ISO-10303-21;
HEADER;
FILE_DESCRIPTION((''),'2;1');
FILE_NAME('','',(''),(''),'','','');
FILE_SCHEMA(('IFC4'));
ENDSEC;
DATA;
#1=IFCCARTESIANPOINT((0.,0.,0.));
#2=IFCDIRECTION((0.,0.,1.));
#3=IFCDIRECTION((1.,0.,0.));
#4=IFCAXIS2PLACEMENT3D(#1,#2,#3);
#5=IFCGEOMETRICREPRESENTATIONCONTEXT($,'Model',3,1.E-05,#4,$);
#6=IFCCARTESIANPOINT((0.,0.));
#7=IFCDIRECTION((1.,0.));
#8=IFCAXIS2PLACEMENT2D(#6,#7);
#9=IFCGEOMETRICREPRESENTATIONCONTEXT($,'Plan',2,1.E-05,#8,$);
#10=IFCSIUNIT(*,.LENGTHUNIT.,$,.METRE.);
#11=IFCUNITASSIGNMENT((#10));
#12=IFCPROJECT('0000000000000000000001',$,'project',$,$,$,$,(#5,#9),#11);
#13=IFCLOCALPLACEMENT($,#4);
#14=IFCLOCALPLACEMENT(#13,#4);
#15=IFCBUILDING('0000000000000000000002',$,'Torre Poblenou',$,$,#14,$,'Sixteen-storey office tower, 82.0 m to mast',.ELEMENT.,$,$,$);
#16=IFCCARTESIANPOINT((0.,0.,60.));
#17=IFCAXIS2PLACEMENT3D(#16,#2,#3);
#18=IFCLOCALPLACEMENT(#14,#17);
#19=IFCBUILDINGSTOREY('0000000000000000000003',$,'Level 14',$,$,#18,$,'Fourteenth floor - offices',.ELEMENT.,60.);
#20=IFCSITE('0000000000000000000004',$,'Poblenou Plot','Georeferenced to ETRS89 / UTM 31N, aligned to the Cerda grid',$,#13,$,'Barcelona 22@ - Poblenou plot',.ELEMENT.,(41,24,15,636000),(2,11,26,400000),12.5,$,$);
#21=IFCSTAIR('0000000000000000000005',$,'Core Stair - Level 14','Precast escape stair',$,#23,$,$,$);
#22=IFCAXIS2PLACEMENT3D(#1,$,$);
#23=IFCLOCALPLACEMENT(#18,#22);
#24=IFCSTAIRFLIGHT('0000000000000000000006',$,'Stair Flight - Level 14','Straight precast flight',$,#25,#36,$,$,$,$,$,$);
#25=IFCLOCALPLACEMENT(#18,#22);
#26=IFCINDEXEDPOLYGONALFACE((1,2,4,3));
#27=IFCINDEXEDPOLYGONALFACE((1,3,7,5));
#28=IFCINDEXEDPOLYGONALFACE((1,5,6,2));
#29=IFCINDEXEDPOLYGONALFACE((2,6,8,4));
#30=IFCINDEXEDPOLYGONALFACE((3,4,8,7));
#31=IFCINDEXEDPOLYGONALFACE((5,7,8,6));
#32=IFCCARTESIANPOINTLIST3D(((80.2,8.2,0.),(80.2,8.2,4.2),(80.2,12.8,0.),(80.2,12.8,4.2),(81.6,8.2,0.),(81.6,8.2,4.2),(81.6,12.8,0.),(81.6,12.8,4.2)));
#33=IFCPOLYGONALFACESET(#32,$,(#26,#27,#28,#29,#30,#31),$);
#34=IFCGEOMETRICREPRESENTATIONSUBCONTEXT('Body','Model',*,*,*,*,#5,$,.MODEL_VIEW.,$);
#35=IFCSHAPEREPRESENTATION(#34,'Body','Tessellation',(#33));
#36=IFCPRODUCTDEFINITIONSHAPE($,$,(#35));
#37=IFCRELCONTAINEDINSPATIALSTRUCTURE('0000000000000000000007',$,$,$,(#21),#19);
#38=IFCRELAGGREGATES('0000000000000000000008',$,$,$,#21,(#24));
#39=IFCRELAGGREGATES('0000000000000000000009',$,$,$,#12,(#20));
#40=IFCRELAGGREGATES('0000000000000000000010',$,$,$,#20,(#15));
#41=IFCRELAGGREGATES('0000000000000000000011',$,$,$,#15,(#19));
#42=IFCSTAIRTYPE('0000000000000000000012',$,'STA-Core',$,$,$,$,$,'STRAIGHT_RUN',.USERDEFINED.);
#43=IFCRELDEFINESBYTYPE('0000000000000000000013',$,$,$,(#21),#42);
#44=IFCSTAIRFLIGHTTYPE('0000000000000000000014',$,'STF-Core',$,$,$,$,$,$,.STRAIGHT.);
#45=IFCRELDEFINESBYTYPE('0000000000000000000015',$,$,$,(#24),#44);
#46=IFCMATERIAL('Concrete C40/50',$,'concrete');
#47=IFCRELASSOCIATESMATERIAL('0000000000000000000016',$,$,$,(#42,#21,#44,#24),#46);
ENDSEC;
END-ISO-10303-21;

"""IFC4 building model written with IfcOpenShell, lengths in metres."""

from ifc_helpers import new_model, si_unit, frame, origin_with_axes, origin_2d_with_axis, place, context, subcontext, project, spatial, line, indexed_curve, outline, extrude, material, type_object, element, aggregate, save


model = new_model("IFC4")

# Units and contexts
model_context = context("Model", 3, precision=1e-05, world=origin_with_axes())
plan_context = context("Plan", 2, precision=1e-05, world=origin_2d_with_axis())
body_context = subcontext(model_context, "Body", "Model", "MODEL_VIEW")
ifc_project = project(units=[si_unit("LENGTHUNIT", "METRE")], contexts=[model_context, plan_context])

# Site, building, storey
site_placement = place(None, origin_with_axes())
site = spatial("IfcSite", under=ifc_project, at=site_placement, Name="Poblenou Plot", Description="Georeferenced to ETRS89 / UTM 31N, aligned to the Cerda grid", LongName="Barcelona 22@ - Poblenou plot", CompositionType="ELEMENT", RefLatitude=(41, 24, 15, 636000), RefLongitude=(2, 11, 26, 400000), RefElevation=12.5)
building_placement = place(site_placement, origin_with_axes())
building = spatial("IfcBuilding", under=site, at=building_placement, Name="Torre Poblenou", LongName="Sixteen-storey office tower, 82.0 m to mast", CompositionType="ELEMENT")
storey_placement = place(building_placement, frame((0.0, 0.0, 60.0), z_axis=(0.0, 0.0, 1.0), x_axis=(1.0, 0.0, 0.0)))
storey = spatial("IfcBuildingStorey", under=building, at=storey_placement, Name="Level 14", LongName="Fourteenth floor - offices", CompositionType="ELEMENT", Elevation=60.0)

# Shared definitions
ifc_material_1 = material(Name="Concrete C40/50", Category="concrete")

# Stair, stair flight
stair_type = type_object("IfcStairType", Name="STA-Core", ElementType="STRAIGHT_RUN", PredefinedType="USERDEFINED", material=ifc_material_1)
stair_placement = place(storey_placement, frame((80.2, 8.2, 0.0), z_axis=(0.0, 0.0, 1.0), x_axis=(1.0, 0.0, 0.0)))
stair = element("IfcStair", 1, at=stair_placement, inside=storey, type_object=stair_type, material=ifc_material_1, Name="Core Stair - Level 14", Description="Precast escape stair")
stair_flight_type = type_object("IfcStairFlightType", Name="STF-Core", PredefinedType="STRAIGHT", material=ifc_material_1)
stair_flight_placement = place(stair_placement, origin_with_axes())
stair_flight = element("IfcStairFlight", 2, at=stair_flight_placement, type_object=stair_flight_type, material=ifc_material_1, Name="Stair Flight - Level 14", Description="Straight precast flight", context=body_context, shape_type="SweptSolid", body=[
    extrude(outline(indexed_curve([(0.0, 0.0), (1.4, 0.0), (1.4, 4.6), (0.0, 4.6)], segments=[line(1, 2, 3, 4, 1)])), origin_with_axes(), (0.0, 0.0, 1.0), 4.2),
])
aggregate(stair, [stair_flight])

save(model, "model.ifc")
